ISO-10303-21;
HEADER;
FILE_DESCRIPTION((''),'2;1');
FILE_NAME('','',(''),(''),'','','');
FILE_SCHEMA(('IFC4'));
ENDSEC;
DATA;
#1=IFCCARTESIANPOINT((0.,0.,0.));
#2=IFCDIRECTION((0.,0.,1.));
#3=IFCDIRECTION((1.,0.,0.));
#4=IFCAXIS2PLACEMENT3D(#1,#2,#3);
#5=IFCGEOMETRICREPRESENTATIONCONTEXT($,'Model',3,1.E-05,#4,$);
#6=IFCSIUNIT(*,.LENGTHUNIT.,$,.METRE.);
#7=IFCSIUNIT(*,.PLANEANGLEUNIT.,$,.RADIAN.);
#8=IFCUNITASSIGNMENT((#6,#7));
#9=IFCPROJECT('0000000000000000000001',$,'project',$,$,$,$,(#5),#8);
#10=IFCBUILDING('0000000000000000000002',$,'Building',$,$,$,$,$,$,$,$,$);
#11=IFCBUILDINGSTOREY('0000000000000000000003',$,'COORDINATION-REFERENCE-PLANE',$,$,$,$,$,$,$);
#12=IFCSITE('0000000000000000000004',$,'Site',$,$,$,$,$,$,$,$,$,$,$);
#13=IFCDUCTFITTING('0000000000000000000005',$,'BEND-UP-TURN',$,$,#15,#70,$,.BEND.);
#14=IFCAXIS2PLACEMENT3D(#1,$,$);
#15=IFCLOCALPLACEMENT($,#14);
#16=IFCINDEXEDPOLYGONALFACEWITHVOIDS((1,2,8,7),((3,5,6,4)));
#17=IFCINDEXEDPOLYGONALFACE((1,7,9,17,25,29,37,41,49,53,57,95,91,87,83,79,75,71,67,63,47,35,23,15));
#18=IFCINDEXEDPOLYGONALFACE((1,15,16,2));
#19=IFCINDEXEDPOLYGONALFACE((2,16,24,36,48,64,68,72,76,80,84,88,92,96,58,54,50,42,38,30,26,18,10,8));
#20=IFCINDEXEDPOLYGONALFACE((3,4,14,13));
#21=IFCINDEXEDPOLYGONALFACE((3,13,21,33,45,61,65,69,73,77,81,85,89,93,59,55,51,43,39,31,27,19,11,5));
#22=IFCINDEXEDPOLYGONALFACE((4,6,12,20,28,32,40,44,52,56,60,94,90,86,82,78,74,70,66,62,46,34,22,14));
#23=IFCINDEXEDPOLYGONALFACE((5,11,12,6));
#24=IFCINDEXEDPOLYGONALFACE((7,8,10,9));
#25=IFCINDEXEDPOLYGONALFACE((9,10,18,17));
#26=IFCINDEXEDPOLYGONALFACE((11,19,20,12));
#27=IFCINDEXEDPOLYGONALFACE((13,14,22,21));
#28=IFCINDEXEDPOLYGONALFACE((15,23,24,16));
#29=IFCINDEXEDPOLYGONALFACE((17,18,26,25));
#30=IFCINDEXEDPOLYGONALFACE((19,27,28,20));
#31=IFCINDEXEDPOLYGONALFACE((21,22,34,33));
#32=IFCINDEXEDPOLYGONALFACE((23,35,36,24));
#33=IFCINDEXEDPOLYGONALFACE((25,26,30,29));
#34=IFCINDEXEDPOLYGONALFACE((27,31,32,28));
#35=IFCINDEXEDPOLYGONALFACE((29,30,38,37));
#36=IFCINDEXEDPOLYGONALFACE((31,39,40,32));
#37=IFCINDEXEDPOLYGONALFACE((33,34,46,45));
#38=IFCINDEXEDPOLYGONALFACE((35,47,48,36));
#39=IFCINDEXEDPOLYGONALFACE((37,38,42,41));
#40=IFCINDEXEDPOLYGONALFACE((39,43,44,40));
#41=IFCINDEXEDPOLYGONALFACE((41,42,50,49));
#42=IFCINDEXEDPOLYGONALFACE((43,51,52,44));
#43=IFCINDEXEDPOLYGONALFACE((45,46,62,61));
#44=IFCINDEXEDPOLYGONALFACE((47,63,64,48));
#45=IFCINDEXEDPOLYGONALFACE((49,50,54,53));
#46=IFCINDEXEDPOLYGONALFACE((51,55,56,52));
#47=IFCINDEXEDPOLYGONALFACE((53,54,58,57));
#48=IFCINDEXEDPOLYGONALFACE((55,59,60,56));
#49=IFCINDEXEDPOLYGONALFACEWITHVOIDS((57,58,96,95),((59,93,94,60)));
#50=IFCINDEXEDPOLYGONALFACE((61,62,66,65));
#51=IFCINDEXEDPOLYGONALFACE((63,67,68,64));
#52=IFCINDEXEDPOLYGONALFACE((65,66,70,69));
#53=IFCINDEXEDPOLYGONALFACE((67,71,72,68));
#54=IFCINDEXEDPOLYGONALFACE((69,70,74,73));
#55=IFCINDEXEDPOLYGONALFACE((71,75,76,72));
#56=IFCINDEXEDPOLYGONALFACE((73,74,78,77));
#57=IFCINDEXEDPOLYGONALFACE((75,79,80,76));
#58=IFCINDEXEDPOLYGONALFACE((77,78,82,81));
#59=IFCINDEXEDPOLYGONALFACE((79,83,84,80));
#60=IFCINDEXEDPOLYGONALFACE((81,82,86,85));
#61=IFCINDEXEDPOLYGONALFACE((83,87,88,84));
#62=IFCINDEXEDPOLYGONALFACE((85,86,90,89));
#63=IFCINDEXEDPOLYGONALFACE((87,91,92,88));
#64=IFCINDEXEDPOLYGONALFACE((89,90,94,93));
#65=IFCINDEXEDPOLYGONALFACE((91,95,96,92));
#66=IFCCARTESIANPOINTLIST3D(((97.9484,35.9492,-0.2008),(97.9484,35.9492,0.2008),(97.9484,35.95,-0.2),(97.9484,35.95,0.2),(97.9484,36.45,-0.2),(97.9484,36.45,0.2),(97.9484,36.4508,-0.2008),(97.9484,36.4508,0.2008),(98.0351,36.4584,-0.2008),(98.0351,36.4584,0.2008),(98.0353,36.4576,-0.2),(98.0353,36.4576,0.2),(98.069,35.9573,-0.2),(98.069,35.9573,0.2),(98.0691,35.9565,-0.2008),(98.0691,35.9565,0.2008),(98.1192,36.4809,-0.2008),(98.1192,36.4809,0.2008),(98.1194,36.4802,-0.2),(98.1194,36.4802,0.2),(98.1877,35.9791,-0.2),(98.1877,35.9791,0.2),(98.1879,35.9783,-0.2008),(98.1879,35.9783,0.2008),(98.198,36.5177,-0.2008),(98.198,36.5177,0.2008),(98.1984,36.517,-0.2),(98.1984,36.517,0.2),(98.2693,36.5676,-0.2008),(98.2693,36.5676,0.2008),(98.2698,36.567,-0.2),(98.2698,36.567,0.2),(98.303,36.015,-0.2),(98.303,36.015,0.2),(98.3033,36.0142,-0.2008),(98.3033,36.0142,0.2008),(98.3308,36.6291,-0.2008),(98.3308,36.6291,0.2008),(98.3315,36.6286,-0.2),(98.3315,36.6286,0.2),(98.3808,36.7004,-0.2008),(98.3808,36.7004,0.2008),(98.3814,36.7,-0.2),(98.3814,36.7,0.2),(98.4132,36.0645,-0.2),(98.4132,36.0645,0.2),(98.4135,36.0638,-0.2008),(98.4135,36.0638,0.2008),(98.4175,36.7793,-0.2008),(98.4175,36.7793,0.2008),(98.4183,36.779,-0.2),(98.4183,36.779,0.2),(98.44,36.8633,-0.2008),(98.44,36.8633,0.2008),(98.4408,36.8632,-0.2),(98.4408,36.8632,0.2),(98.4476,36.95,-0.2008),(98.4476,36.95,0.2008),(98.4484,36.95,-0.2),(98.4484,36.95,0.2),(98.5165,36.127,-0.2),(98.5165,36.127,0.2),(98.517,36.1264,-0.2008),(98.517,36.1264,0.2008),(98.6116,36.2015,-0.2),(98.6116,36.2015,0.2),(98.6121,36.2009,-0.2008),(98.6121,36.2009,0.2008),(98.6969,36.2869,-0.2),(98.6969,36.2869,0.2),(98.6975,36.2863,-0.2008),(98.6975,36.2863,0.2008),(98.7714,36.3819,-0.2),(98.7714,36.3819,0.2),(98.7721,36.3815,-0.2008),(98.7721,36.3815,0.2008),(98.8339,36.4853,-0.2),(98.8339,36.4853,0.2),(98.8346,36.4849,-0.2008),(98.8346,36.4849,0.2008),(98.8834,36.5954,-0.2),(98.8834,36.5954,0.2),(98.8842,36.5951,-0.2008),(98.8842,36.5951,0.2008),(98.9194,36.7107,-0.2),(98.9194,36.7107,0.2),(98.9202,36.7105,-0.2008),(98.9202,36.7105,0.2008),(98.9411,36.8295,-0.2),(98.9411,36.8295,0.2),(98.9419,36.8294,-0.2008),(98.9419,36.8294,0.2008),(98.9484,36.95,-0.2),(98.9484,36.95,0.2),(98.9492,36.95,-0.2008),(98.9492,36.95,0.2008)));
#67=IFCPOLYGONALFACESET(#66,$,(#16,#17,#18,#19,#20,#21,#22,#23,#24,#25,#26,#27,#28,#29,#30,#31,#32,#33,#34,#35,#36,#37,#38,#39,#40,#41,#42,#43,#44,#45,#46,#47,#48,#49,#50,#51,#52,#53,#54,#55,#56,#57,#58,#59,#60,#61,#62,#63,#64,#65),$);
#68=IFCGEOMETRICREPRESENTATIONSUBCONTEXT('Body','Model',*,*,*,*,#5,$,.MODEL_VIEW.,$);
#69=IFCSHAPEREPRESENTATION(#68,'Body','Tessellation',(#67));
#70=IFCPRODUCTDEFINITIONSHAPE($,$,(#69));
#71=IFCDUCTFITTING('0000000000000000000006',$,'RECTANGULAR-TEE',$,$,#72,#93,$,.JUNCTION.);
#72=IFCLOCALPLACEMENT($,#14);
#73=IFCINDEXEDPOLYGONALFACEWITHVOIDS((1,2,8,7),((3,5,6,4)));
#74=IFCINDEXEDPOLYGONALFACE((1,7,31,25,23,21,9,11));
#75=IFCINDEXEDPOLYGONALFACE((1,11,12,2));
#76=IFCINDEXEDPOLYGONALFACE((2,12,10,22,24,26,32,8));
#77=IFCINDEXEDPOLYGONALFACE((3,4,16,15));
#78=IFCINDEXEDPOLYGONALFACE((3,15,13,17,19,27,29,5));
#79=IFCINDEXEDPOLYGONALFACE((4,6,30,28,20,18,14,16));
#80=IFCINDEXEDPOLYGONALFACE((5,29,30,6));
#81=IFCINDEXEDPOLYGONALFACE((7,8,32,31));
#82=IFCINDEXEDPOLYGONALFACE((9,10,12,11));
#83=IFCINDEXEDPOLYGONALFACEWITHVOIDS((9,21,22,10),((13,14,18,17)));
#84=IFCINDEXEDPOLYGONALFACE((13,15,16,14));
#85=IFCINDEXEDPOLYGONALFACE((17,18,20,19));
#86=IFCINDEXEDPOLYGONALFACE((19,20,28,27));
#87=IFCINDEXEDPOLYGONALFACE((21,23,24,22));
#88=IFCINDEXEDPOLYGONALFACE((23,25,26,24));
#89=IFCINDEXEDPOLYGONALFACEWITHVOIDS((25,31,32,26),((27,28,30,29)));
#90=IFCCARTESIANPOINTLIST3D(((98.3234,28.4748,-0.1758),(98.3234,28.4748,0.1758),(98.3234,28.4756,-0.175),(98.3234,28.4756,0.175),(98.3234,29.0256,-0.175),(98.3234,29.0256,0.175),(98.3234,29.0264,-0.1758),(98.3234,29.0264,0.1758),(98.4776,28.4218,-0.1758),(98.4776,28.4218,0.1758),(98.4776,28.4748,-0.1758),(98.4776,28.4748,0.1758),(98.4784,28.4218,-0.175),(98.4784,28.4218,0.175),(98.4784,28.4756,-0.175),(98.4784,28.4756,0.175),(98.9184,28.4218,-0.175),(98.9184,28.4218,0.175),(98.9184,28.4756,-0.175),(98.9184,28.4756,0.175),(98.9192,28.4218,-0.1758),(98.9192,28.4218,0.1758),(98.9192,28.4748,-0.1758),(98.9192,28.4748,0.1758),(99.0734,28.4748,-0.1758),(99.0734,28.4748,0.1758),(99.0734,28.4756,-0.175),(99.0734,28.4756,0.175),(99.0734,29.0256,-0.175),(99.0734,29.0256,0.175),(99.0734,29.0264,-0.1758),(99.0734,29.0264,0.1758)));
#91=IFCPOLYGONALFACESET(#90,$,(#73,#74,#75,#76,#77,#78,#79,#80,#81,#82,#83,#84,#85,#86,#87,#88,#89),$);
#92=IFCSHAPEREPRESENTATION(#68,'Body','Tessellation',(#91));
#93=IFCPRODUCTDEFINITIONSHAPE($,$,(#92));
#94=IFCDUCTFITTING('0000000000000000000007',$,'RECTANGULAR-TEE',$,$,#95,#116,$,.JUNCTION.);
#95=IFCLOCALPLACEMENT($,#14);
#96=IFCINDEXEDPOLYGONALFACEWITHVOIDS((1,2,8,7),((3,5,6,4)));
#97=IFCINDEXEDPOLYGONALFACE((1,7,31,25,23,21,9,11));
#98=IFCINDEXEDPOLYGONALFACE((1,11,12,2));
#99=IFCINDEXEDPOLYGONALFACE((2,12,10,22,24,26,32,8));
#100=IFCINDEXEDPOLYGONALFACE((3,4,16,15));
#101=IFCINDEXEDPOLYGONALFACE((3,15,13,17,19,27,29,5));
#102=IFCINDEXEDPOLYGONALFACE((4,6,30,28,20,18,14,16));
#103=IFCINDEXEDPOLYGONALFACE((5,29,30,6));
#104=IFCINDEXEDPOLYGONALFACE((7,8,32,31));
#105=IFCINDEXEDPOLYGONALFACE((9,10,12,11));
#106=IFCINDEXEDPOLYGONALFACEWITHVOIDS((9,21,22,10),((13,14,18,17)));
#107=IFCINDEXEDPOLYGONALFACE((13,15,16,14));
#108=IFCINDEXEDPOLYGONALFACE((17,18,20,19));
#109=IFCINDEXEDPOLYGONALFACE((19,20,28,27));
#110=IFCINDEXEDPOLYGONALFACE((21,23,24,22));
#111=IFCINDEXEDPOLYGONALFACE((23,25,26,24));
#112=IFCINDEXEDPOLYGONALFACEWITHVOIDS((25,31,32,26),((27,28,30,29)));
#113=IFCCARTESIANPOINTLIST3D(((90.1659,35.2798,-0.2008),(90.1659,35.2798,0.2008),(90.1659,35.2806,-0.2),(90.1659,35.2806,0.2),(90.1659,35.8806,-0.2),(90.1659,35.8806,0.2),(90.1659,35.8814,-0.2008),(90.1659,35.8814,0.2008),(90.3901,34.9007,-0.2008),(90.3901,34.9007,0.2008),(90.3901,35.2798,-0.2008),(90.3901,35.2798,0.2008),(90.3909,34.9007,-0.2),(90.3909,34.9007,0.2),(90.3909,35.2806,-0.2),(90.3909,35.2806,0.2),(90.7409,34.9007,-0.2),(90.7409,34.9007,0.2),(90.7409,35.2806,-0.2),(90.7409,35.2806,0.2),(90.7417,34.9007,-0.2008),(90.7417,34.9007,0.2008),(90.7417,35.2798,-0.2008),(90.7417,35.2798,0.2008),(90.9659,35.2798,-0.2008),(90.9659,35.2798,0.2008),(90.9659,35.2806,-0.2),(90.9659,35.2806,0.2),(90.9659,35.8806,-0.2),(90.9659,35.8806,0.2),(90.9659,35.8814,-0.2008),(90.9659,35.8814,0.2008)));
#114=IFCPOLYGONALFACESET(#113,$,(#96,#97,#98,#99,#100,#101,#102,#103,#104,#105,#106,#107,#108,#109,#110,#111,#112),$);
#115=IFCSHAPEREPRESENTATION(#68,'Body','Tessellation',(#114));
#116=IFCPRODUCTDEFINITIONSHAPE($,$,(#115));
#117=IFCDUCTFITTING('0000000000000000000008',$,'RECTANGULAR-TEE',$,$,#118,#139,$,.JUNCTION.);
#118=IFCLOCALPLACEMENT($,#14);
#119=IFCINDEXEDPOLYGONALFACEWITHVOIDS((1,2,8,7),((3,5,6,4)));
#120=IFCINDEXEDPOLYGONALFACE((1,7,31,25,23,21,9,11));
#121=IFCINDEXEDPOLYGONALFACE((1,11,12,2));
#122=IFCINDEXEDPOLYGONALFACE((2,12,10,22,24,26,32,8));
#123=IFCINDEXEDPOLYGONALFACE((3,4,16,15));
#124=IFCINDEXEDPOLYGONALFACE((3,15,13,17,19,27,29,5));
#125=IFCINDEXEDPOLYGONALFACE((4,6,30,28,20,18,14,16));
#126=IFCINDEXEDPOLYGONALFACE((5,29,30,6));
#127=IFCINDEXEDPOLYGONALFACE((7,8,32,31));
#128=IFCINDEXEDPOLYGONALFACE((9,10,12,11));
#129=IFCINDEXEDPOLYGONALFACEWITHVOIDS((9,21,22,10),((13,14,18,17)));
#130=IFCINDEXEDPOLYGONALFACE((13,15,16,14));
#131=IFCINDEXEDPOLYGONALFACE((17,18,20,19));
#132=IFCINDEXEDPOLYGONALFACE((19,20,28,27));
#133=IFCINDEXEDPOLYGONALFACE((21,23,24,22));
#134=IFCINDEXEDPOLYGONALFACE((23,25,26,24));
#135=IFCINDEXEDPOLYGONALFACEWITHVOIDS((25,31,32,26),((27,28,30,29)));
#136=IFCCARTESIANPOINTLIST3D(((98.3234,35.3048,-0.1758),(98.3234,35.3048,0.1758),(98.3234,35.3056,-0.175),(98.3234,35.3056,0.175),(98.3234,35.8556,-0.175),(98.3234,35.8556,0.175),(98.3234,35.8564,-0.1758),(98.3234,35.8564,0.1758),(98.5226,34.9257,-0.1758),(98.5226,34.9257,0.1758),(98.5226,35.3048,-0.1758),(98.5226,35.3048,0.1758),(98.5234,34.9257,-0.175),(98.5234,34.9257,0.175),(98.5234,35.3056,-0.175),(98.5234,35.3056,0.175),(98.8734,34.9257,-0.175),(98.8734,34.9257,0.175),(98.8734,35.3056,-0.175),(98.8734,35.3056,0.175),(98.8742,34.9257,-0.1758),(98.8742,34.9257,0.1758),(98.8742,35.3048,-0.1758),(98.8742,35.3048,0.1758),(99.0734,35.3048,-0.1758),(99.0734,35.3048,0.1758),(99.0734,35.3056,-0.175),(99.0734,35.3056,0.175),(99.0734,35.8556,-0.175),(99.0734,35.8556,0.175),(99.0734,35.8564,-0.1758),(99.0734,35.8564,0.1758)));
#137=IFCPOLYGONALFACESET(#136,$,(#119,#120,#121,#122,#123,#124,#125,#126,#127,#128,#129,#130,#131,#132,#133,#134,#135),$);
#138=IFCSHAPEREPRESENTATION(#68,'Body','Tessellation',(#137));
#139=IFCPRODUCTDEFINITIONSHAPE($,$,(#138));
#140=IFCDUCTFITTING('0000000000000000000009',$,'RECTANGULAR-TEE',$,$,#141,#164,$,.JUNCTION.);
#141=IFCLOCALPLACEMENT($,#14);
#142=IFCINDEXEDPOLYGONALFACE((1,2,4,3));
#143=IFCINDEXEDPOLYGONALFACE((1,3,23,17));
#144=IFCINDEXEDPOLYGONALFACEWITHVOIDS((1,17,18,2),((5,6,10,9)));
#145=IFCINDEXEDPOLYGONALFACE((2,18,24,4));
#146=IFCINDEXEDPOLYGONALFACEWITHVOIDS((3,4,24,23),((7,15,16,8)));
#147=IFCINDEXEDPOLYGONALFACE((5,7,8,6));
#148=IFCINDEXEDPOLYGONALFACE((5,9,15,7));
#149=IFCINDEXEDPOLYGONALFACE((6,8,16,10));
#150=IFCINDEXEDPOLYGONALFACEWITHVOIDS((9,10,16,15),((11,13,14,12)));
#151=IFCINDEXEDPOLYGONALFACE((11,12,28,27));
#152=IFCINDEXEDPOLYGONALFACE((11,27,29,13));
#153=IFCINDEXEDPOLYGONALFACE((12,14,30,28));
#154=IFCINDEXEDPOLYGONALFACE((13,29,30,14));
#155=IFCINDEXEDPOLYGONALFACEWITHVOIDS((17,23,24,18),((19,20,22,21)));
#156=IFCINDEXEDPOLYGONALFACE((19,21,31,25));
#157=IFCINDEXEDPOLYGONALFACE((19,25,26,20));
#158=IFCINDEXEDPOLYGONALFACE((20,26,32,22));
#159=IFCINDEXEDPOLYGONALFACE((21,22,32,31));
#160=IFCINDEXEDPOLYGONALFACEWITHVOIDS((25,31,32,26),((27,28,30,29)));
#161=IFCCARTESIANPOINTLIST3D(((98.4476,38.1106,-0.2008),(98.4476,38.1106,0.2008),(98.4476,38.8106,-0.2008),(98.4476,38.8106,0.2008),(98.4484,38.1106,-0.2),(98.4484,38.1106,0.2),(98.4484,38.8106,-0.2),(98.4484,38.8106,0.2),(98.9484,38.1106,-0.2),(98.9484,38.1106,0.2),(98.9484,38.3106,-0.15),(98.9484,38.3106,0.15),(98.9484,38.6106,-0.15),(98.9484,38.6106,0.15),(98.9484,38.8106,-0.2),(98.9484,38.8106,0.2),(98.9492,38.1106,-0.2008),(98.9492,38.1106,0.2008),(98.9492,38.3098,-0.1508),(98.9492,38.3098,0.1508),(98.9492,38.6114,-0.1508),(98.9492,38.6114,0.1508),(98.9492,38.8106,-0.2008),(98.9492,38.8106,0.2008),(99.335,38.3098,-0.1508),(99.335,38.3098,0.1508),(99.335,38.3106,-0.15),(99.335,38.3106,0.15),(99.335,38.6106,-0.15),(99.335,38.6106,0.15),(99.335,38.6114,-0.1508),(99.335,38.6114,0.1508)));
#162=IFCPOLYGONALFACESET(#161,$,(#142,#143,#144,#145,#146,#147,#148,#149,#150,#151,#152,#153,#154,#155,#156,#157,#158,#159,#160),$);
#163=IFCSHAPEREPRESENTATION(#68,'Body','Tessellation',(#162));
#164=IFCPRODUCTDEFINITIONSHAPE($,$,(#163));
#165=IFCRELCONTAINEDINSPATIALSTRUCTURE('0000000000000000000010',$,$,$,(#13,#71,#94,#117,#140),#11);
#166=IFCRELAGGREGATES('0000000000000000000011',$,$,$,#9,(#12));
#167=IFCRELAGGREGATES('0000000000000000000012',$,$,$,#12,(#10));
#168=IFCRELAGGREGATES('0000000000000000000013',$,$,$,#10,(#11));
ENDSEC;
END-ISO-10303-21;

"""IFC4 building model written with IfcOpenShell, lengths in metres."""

from ifc_helpers import new_model, entity, si_unit, frame, origin_with_axes, place, context, subcontext, project, spatial, rectangle, extrude, boolean, element, save


model = new_model("IFC4")

# Units and contexts
model_context = context("Model", 3, precision=1e-05, world=origin_with_axes())
body_context_1 = subcontext(model_context, "Body", "Model", "MODEL_VIEW")
ifc_project = project(units=[si_unit("LENGTHUNIT", "METRE"), si_unit("PLANEANGLEUNIT", "RADIAN")], contexts=[model_context])

# Site, building, storey
site = spatial("IfcSite", under=ifc_project, Name="Site")
building = spatial("IfcBuilding", under=site, Name="Building")
storey = spatial("IfcBuildingStorey", under=building, Name="COORDINATION-REFERENCE-PLANE")

# Duct fittings
duct_fitting_1_placement = place(None, frame((97.9484, 36.95, 0.0), z_axis=(0.0, 0.0, 1.0), x_axis=(0.0, -1.0, 0.0)))
cartesian_point_1 = entity("IfcCartesianPoint", [0.0, 0.0, 0.0])
element("IfcDuctFitting", 1, at=duct_fitting_1_placement, inside=storey, Name="BEND-UP-TURN", PredefinedType="BEND", context=body_context_1, shape_type="SweptSolid", body=[
    entity("IfcRevolvedAreaSolid", entity("IfcRectangleHollowProfileDef", "AREA", None, entity("IfcAxis2Placement2D", entity("IfcCartesianPoint", [0.75, 0.0])), 0.5016, 0.4016, 0.0008), entity("IfcAxis2Placement3D", cartesian_point_1, entity("IfcDirection", [0.0, -1.0, 0.0]), entity("IfcDirection", [1.0, 0.0, 0.0])), entity("IfcAxis1Placement", cartesian_point_1, entity("IfcDirection", [0.0, 1.0, 0.0])), 1.570796),
])
duct_fitting_2_placement = place(None, frame((98.6984, 28.7506, 0.0), z_axis=(1.0, 0.0, 0.0), x_axis=(0.0, -1.0, 0.0)))
solid_1 = boolean("UNION", extrude(rectangle(XDim=0.55, YDim=0.35), frame((0.0, 0.0, -0.375), z_axis=(0.0, 0.0, 1.0), x_axis=(1.0, 0.0, 0.0)), (0.0, 0.0, 1.0), 0.75), extrude(rectangle(XDim=0.44, YDim=0.35), frame((0.0, 0.0, 0.0), z_axis=(1.0, 0.0, 0.0), x_axis=(0.0, 0.0, -1.0)), (0.0, 0.0, 1.0), 0.3288))
element("IfcDuctFitting", 2, at=duct_fitting_2_placement, inside=storey, Name="RECTANGULAR-TEE", PredefinedType="JUNCTION", context=body_context_1, shape_type="CSG", body=[
    boolean("DIFFERENCE", boolean("UNION", extrude(rectangle(XDim=0.5516, YDim=0.3516), frame((0.0, 0.0, -0.375), z_axis=(0.0, 0.0, 1.0), x_axis=(1.0, 0.0, 0.0)), (0.0, 0.0, 1.0), 0.75), extrude(rectangle(XDim=0.4416, YDim=0.3516), frame((0.0, 0.0, 0.0), z_axis=(1.0, 0.0, 0.0), x_axis=(0.0, 0.0, -1.0)), (0.0, 0.0, 1.0), 0.3288)), solid_1),
])
duct_fitting_3_placement = place(None, frame((90.5659, 35.5806, 0.0), z_axis=(1.0, 0.0, 0.0), x_axis=(0.0, -1.0, 0.0)))
solid_2 = boolean("UNION", extrude(rectangle(XDim=0.6, YDim=0.4), frame((0.0, 0.0, -0.4), z_axis=(0.0, 0.0, 1.0), x_axis=(1.0, 0.0, 0.0)), (0.0, 0.0, 1.0), 0.8), extrude(rectangle(XDim=0.35, YDim=0.4), frame((0.0, 0.0, 0.0), z_axis=(1.0, 0.0, 0.0), x_axis=(0.0, 0.0, -1.0)), (0.0, 0.0, 1.0), 0.6799))
element("IfcDuctFitting", 3, at=duct_fitting_3_placement, inside=storey, Name="RECTANGULAR-TEE", PredefinedType="JUNCTION", context=body_context_1, shape_type="CSG", body=[
    boolean("DIFFERENCE", boolean("UNION", extrude(rectangle(XDim=0.6016, YDim=0.4016), frame((0.0, 0.0, -0.4), z_axis=(0.0, 0.0, 1.0), x_axis=(1.0, 0.0, 0.0)), (0.0, 0.0, 1.0), 0.8), extrude(rectangle(XDim=0.3516, YDim=0.4016), frame((0.0, 0.0, 0.0), z_axis=(1.0, 0.0, 0.0), x_axis=(0.0, 0.0, -1.0)), (0.0, 0.0, 1.0), 0.6799)), solid_2),
])
duct_fitting_4_placement = place(None, frame((98.6984, 35.5806, 0.0), z_axis=(1.0, 0.0, 0.0), x_axis=(0.0, -1.0, 0.0)))
solid_3 = boolean("UNION", extrude(rectangle(XDim=0.55, YDim=0.35), frame((0.0, 0.0, -0.375), z_axis=(0.0, 0.0, 1.0), x_axis=(1.0, 0.0, 0.0)), (0.0, 0.0, 1.0), 0.75), extrude(rectangle(XDim=0.35, YDim=0.35), frame((0.0, 0.0, 0.0), z_axis=(1.0, 0.0, 0.0), x_axis=(0.0, 0.0, -1.0)), (0.0, 0.0, 1.0), 0.6549))
element("IfcDuctFitting", 4, at=duct_fitting_4_placement, inside=storey, Name="RECTANGULAR-TEE", PredefinedType="JUNCTION", context=body_context_1, shape_type="CSG", body=[
    boolean("DIFFERENCE", boolean("UNION", extrude(rectangle(XDim=0.5516, YDim=0.3516), frame((0.0, 0.0, -0.375), z_axis=(0.0, 0.0, 1.0), x_axis=(1.0, 0.0, 0.0)), (0.0, 0.0, 1.0), 0.75), extrude(rectangle(XDim=0.3516, YDim=0.3516), frame((0.0, 0.0, 0.0), z_axis=(1.0, 0.0, 0.0), x_axis=(0.0, 0.0, -1.0)), (0.0, 0.0, 1.0), 0.6549)), solid_3),
])
duct_fitting_5_placement = place(None, frame((98.6984, 38.4606, 0.0), z_axis=(0.0, 1.0, 0.0), x_axis=(1.0, 0.0, 0.0)))
solid_4 = boolean("UNION", extrude(rectangle(XDim=0.5, YDim=0.4), frame((0.0, 0.0, -0.35), z_axis=(0.0, 0.0, 1.0), x_axis=(1.0, 0.0, 0.0)), (0.0, 0.0, 1.0), 0.7), extrude(rectangle(XDim=0.3, YDim=0.3), frame((0.0, 0.0, 0.0), z_axis=(1.0, 0.0, 0.0), x_axis=(0.0, 0.0, -1.0)), (0.0, 0.0, 1.0), 0.6366))
element("IfcDuctFitting", 5, at=duct_fitting_5_placement, inside=storey, Name="RECTANGULAR-TEE", PredefinedType="JUNCTION", context=body_context_1, shape_type="CSG", body=[
    boolean("DIFFERENCE", boolean("UNION", extrude(rectangle(XDim=0.5016, YDim=0.4016), frame((0.0, 0.0, -0.35), z_axis=(0.0, 0.0, 1.0), x_axis=(1.0, 0.0, 0.0)), (0.0, 0.0, 1.0), 0.7), extrude(rectangle(XDim=0.3016, YDim=0.3016), frame((0.0, 0.0, 0.0), z_axis=(1.0, 0.0, 0.0), x_axis=(0.0, 0.0, -1.0)), (0.0, 0.0, 1.0), 0.6366)), solid_4),
])

save(model, "model.ifc")
